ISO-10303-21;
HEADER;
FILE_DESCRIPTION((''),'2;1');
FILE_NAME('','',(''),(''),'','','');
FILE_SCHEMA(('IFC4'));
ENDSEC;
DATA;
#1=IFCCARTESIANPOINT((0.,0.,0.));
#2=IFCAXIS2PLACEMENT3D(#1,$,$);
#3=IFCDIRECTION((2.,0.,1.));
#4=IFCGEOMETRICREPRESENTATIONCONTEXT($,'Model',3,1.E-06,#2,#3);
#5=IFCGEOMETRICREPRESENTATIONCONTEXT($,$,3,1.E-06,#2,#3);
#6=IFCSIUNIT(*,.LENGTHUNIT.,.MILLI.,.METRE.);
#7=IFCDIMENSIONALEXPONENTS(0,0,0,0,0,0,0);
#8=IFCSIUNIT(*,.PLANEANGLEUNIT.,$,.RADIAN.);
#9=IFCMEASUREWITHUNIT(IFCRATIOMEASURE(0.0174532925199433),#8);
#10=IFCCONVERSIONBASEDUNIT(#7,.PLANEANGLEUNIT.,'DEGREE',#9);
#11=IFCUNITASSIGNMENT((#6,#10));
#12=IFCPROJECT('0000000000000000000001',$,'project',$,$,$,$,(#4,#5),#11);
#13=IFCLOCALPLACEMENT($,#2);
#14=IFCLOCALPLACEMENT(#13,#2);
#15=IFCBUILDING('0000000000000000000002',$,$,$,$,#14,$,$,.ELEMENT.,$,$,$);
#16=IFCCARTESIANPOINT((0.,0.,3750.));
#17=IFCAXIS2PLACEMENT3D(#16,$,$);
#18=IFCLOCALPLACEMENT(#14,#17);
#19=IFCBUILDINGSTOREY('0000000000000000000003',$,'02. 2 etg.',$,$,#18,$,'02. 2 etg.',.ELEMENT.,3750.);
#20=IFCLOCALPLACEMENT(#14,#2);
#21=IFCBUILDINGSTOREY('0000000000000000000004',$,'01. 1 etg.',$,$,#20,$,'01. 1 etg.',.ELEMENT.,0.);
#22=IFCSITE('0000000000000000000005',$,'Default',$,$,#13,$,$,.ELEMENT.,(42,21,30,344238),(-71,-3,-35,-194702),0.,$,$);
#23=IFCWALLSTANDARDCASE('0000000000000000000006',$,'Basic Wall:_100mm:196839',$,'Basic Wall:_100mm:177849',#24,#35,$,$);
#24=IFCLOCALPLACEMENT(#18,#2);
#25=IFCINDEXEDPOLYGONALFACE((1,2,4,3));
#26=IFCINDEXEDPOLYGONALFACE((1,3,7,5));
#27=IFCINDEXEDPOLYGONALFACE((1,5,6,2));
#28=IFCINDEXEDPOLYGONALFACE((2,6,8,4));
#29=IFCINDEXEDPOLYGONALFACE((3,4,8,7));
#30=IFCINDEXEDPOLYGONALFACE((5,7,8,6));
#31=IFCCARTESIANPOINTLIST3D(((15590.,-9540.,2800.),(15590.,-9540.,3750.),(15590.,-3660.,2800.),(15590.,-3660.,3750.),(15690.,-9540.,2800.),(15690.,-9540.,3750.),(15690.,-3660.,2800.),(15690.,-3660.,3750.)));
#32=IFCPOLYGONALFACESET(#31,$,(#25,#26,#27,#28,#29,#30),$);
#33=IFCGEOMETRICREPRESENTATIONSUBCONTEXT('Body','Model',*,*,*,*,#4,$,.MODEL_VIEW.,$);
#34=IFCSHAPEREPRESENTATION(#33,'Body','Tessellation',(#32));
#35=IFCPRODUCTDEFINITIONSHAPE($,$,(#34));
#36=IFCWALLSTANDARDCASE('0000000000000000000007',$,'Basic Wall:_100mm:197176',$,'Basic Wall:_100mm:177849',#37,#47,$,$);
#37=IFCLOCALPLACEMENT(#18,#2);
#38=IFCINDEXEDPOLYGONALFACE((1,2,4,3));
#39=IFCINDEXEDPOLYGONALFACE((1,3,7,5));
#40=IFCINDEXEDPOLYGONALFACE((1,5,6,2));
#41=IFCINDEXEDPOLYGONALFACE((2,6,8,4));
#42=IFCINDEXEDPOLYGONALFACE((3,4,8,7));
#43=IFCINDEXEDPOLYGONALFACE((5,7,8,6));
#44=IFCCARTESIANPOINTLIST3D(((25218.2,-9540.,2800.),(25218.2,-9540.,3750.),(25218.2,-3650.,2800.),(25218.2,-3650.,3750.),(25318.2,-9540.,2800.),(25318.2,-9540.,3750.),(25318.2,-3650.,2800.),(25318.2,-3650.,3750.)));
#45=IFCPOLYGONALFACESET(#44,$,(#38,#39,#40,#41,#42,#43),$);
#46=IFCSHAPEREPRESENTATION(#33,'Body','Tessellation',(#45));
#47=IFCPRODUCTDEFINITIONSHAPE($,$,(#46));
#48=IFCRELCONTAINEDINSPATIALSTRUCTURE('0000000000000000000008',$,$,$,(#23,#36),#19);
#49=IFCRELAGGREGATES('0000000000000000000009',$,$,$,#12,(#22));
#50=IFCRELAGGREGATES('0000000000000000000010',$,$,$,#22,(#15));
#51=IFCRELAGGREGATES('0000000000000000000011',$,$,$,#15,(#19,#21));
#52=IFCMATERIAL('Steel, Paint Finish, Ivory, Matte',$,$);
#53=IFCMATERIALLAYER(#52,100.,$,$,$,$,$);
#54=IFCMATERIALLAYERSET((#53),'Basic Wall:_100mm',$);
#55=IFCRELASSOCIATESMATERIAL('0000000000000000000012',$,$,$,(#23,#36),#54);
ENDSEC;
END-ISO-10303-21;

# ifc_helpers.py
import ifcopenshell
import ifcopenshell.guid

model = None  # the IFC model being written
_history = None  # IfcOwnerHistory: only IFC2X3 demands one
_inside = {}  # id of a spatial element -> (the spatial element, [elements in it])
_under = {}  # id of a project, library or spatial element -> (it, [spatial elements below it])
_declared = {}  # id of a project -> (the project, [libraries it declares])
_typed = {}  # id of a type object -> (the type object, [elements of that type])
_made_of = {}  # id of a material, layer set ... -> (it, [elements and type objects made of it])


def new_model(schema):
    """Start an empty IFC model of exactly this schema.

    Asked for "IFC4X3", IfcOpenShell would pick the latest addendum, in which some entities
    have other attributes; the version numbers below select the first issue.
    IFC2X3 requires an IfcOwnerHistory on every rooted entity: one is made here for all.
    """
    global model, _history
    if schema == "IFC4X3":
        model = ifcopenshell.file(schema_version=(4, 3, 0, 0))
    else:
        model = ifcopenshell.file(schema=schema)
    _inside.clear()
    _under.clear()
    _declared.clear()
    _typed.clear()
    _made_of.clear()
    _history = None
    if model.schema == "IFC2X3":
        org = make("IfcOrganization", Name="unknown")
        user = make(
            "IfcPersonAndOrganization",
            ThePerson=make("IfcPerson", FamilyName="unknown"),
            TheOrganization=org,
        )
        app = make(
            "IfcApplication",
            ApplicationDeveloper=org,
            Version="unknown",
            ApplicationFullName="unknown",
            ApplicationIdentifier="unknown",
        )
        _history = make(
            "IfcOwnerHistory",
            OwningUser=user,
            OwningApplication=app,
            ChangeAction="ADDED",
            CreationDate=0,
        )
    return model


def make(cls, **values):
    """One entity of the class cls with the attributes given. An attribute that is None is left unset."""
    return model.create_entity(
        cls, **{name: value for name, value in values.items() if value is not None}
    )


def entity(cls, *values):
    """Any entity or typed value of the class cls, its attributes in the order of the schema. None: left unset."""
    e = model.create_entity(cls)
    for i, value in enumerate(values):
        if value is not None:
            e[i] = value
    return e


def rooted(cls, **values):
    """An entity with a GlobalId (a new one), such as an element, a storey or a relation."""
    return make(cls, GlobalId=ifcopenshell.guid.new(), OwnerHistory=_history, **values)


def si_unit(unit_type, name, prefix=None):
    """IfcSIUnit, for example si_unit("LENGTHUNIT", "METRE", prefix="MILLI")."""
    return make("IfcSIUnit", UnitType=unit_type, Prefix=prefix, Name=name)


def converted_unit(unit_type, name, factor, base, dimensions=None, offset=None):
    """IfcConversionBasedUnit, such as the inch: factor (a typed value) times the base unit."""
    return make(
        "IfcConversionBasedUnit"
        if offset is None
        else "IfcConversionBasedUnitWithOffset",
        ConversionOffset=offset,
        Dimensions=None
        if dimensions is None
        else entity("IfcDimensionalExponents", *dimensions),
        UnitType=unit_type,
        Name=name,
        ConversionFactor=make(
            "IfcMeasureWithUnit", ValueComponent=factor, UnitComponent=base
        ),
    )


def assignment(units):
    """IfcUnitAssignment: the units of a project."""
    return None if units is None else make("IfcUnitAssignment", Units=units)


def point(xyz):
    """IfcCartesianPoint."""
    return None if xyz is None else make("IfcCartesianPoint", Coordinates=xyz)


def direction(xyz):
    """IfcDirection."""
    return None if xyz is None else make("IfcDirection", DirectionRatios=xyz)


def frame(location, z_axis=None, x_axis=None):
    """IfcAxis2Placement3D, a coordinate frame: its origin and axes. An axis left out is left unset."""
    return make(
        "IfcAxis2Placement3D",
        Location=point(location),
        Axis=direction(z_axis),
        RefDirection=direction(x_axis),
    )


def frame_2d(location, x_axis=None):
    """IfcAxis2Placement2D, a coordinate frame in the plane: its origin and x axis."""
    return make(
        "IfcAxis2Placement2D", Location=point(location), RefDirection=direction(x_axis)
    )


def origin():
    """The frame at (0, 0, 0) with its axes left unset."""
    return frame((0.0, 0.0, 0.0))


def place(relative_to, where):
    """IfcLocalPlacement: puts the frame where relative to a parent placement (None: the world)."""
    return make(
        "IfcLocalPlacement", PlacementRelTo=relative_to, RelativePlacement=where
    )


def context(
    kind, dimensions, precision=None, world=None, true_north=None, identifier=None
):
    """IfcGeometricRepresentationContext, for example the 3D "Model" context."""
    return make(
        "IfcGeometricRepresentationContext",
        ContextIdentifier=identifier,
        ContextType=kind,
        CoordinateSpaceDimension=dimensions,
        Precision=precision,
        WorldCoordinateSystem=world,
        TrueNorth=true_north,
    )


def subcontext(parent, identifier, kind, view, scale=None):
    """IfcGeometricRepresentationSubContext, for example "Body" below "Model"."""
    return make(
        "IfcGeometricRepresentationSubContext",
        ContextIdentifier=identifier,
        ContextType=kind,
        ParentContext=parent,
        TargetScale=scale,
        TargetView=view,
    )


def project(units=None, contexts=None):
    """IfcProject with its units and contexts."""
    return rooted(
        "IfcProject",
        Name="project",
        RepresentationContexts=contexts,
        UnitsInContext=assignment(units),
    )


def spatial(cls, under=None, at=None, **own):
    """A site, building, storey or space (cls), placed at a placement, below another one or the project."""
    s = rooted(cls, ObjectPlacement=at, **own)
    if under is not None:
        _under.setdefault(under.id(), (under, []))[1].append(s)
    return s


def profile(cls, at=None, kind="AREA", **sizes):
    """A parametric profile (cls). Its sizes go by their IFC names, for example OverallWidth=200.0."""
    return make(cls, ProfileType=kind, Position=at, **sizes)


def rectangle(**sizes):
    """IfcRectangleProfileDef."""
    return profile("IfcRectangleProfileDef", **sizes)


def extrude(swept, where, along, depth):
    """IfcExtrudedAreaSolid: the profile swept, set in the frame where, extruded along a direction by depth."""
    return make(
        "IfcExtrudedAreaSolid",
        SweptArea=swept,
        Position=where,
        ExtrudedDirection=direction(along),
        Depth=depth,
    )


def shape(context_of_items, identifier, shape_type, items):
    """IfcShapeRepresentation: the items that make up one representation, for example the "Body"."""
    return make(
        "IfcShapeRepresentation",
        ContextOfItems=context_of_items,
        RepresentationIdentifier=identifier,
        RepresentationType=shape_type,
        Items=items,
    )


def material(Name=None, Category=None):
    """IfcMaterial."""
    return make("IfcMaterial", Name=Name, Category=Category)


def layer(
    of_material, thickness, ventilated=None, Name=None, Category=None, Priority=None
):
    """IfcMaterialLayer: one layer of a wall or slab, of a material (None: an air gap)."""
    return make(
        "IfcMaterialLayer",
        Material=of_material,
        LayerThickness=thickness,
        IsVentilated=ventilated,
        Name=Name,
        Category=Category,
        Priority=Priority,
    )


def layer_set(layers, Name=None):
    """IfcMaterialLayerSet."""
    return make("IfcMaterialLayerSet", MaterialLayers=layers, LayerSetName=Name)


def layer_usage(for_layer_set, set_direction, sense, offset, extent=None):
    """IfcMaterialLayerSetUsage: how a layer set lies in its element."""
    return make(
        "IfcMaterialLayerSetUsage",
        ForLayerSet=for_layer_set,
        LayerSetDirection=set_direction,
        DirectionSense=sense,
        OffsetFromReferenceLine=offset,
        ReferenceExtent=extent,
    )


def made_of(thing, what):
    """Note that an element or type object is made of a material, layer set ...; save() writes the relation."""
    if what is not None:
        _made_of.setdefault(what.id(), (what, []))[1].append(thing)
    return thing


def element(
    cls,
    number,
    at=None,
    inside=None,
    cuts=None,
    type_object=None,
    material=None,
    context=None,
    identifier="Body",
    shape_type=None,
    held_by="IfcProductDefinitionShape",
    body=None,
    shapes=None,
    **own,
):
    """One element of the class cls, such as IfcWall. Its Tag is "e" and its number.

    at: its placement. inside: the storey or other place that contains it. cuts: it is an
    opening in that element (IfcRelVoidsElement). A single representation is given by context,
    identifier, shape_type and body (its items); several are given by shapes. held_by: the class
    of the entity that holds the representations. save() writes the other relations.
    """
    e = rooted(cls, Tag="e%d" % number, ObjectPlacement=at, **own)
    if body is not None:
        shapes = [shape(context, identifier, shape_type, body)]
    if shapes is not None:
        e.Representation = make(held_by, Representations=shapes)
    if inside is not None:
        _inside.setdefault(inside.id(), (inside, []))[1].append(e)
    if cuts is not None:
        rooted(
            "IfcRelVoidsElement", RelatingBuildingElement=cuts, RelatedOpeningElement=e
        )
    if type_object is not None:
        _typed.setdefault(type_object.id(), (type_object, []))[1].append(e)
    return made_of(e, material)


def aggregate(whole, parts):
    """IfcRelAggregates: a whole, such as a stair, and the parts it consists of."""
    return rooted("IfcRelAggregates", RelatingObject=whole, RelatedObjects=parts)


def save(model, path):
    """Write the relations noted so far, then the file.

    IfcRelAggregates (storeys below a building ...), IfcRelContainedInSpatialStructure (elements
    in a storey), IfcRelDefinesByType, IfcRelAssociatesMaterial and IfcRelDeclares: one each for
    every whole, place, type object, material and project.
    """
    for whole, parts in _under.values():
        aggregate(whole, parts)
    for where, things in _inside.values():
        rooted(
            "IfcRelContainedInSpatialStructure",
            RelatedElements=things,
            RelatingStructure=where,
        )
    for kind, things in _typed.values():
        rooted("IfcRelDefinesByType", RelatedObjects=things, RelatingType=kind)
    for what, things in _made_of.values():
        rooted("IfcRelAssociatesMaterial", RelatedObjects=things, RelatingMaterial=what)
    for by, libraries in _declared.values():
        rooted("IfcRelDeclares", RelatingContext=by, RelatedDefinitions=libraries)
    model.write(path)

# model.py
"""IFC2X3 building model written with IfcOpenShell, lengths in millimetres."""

from ifc_helpers import new_model, entity, si_unit, converted_unit, direction, frame, frame_2d, origin, place, context, subcontext, project, spatial, rectangle, extrude, material, layer, layer_set, layer_usage, element, save


model = new_model("IFC2X3")

# Units and contexts
model_context = context("Model", 3, precision=1e-06, world=origin(), true_north=direction((2.0, 0.0, 1.0)))
context_of_model = context(None, 3, precision=1e-06, world=origin(), true_north=direction((2.0, 0.0, 1.0)))
body_context = subcontext(model_context, "Body", "Model", "MODEL_VIEW")
ifc_project = project(units=[si_unit("LENGTHUNIT", "METRE", prefix="MILLI"), converted_unit("PLANEANGLEUNIT", "DEGREE", entity("IfcRatioMeasure", 0.0174532925199433), si_unit("PLANEANGLEUNIT", "RADIAN"), dimensions=[0, 0, 0, 0, 0, 0, 0])], contexts=[model_context, context_of_model])

# Site, building, storey
site_placement = place(None, origin())
site = spatial("IfcSite", under=ifc_project, at=site_placement, Name="Default", CompositionType="ELEMENT", RefLatitude=(42, 21, 30, 344238), RefLongitude=(-71, -3, -35, -194702), RefElevation=0.0)
building_placement = place(site_placement, origin())
building = spatial("IfcBuilding", under=site, at=building_placement, CompositionType="ELEMENT")
storey_1_placement = place(building_placement, frame((0.0, 0.0, 3750.0)))
storey_1 = spatial("IfcBuildingStorey", under=building, at=storey_1_placement, Name="02. 2 etg.", LongName="02. 2 etg.", CompositionType="ELEMENT", Elevation=3750.0)

# Shared definitions
ifc_material_1 = material(Name="Steel, Paint Finish, Ivory, Matte")
ifc_layer_1 = layer(ifc_material_1, 100.0)
ifc_layer_set_1 = layer_set([ifc_layer_1], Name="Basic Wall:_100mm")

# Shared definitions
storey_2_placement = place(building_placement, origin())
storey_2 = spatial("IfcBuildingStorey", under=building, at=storey_2_placement, Name="01. 1 etg.", LongName="01. 1 etg.", CompositionType="ELEMENT", Elevation=0.0)

# Walls
ifc_layer_usage_1 = layer_usage(ifc_layer_set_1, "AXIS2", "NEGATIVE", 50.0)
wall_1_placement = place(storey_1_placement, frame((15640.0, -3660.0, 2800.0), z_axis=(0.0, 0.0, 1.0), x_axis=(0.0, -1.0, 0.0)))
element("IfcWallStandardCase", 1, at=wall_1_placement, inside=storey_1, material=ifc_layer_usage_1, Name="Basic Wall:_100mm:196839", ObjectType="Basic Wall:_100mm:177849", context=body_context, shape_type="SweptSolid", body=[
    extrude(rectangle(XDim=5880.0, YDim=100.0, at=frame_2d((2940.0, 0.0), x_axis=(-1.0, 0.0))), origin(), (0.0, 0.0, 1.0), 950.0),
])
ifc_layer_usage_2 = layer_usage(ifc_layer_set_1, "AXIS2", "NEGATIVE", 50.0)
wall_2_placement = place(storey_1_placement, frame((25268.2, -3650.0, 2800.0), z_axis=(0.0, 0.0, 1.0), x_axis=(0.0, -1.0, 0.0)))
element("IfcWallStandardCase", 2, at=wall_2_placement, inside=storey_1, material=ifc_layer_usage_2, Name="Basic Wall:_100mm:197176", ObjectType="Basic Wall:_100mm:177849", context=body_context, shape_type="SweptSolid", body=[
    extrude(rectangle(XDim=5890.0, YDim=100.0, at=frame_2d((2945.0, 0.0), x_axis=(-1.0, 0.0))), origin(), (0.0, 0.0, 1.0), 950.0),
])

save(model, "model.ifc")
